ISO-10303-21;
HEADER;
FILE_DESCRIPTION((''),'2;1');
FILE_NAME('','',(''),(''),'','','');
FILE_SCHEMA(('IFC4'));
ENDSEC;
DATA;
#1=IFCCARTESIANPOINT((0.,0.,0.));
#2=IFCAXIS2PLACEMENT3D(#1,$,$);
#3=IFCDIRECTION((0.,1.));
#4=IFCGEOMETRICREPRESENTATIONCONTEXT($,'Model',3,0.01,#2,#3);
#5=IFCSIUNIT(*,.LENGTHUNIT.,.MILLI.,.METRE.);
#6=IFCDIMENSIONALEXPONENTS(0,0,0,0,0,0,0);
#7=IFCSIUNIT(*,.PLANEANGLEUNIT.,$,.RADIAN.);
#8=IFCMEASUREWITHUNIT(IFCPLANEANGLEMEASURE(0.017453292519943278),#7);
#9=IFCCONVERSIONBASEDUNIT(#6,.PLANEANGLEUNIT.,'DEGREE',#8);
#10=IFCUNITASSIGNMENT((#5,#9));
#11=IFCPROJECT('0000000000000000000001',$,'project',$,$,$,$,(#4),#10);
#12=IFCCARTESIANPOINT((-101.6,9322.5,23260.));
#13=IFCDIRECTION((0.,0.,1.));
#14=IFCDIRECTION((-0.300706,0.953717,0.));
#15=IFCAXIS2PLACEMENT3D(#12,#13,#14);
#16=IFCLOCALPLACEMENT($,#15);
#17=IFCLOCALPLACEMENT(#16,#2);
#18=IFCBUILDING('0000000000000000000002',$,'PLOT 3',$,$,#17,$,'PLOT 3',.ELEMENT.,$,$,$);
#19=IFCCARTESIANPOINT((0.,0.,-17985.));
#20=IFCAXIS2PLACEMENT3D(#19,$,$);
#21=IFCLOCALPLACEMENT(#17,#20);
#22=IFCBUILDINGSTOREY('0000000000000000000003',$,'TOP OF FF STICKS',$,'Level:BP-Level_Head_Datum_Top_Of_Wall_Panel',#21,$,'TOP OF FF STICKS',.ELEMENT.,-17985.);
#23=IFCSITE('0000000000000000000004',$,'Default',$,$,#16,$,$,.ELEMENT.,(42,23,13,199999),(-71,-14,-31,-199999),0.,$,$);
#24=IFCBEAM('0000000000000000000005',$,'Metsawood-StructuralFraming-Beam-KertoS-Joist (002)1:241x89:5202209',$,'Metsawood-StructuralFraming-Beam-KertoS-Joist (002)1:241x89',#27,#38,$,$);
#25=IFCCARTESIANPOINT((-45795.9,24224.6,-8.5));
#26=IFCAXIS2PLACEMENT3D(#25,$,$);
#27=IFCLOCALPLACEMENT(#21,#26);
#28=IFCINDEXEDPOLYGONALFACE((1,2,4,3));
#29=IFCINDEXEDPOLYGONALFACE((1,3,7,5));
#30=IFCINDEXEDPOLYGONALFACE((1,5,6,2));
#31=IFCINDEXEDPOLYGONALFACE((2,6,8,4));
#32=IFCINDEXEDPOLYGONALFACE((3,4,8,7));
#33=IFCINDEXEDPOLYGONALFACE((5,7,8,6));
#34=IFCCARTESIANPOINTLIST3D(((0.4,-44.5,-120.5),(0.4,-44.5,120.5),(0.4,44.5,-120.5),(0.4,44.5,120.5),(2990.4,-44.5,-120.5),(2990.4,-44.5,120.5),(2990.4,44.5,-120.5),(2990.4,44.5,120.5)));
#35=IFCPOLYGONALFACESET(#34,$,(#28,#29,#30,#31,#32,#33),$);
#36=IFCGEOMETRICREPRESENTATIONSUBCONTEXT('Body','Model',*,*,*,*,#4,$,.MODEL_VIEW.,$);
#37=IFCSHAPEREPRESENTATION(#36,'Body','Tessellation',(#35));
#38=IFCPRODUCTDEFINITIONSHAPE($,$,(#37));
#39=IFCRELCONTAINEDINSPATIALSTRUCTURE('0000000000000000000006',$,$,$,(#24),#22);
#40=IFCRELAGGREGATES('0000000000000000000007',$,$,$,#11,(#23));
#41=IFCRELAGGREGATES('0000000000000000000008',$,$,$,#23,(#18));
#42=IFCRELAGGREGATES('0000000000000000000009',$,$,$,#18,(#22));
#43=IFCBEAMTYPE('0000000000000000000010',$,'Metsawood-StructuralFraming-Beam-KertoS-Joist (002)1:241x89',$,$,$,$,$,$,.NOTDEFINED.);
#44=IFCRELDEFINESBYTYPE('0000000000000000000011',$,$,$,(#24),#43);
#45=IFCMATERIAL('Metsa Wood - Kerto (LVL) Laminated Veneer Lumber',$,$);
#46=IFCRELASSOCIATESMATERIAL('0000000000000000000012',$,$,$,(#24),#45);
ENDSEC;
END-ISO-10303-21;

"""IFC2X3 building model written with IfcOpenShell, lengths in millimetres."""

from ifc_helpers import new_model, entity, si_unit, converted_unit, direction, frame, frame_2d, origin, place, context, subcontext, project, spatial, rectangle, extrude, material, type_object, element, save


model = new_model("IFC2X3")

# Units and contexts
model_context = context("Model", 3, precision=0.01, world=origin(), true_north=direction((0.0, 1.0)))
body_context = subcontext(model_context, "Body", "Model", "MODEL_VIEW")
ifc_project = project(units=[si_unit("LENGTHUNIT", "METRE", prefix="MILLI"), converted_unit("PLANEANGLEUNIT", "DEGREE", entity("IfcPlaneAngleMeasure", 0.017453292519943278), si_unit("PLANEANGLEUNIT", "RADIAN"), dimensions=[0, 0, 0, 0, 0, 0, 0])], contexts=[model_context])

# Site, building, storey
site_placement = place(None, frame((-101.6, 9322.5, 23260.0), z_axis=(0.0, 0.0, 1.0), x_axis=(-0.300706, 0.953717, 0.0)))
site = spatial("IfcSite", under=ifc_project, at=site_placement, Name="Default", CompositionType="ELEMENT", RefLatitude=(42, 23, 13, 199999), RefLongitude=(-71, -14, -31, -199999), RefElevation=0.0)
building_placement = place(site_placement, origin())
building = spatial("IfcBuilding", under=site, at=building_placement, Name="PLOT 3", LongName="PLOT 3", CompositionType="ELEMENT")
storey_placement = place(building_placement, frame((0.0, 0.0, -17985.0)))
storey = spatial("IfcBuildingStorey", under=building, at=storey_placement, Name="TOP OF FF STICKS", ObjectType="Level:BP-Level_Head_Datum_Top_Of_Wall_Panel", LongName="TOP OF FF STICKS", CompositionType="ELEMENT", Elevation=-17985.0)

# Beam
ifc_material_1 = material(Name="Metsa Wood - Kerto (LVL) Laminated Veneer Lumber")
beam_type = type_object("IfcBeamType", Name="Metsawood-StructuralFraming-Beam-KertoS-Joist (002)1:241x89", PredefinedType="NOTDEFINED")
beam_placement = place(storey_placement, frame((-45795.9, 24224.6, -8.5)))
element("IfcBeam", 1, at=beam_placement, inside=storey, type_object=beam_type, material=ifc_material_1, Name="Metsawood-StructuralFraming-Beam-KertoS-Joist (002)1:241x89:5202209", ObjectType="Metsawood-StructuralFraming-Beam-KertoS-Joist (002)1:241x89", context=body_context, shape_type="SweptSolid", body=[
    extrude(rectangle(XDim=241.0, YDim=89.0, at=frame_2d((0.0, 0.0), x_axis=(1.0, 0.0))), frame((0.4, 0.0, 0.0), z_axis=(1.0, 0.0, 0.0), x_axis=(0.0, 0.0, -1.0)), (0.0, 0.0, 1.0), 2990.0),
])

save(model, "model.ifc")
